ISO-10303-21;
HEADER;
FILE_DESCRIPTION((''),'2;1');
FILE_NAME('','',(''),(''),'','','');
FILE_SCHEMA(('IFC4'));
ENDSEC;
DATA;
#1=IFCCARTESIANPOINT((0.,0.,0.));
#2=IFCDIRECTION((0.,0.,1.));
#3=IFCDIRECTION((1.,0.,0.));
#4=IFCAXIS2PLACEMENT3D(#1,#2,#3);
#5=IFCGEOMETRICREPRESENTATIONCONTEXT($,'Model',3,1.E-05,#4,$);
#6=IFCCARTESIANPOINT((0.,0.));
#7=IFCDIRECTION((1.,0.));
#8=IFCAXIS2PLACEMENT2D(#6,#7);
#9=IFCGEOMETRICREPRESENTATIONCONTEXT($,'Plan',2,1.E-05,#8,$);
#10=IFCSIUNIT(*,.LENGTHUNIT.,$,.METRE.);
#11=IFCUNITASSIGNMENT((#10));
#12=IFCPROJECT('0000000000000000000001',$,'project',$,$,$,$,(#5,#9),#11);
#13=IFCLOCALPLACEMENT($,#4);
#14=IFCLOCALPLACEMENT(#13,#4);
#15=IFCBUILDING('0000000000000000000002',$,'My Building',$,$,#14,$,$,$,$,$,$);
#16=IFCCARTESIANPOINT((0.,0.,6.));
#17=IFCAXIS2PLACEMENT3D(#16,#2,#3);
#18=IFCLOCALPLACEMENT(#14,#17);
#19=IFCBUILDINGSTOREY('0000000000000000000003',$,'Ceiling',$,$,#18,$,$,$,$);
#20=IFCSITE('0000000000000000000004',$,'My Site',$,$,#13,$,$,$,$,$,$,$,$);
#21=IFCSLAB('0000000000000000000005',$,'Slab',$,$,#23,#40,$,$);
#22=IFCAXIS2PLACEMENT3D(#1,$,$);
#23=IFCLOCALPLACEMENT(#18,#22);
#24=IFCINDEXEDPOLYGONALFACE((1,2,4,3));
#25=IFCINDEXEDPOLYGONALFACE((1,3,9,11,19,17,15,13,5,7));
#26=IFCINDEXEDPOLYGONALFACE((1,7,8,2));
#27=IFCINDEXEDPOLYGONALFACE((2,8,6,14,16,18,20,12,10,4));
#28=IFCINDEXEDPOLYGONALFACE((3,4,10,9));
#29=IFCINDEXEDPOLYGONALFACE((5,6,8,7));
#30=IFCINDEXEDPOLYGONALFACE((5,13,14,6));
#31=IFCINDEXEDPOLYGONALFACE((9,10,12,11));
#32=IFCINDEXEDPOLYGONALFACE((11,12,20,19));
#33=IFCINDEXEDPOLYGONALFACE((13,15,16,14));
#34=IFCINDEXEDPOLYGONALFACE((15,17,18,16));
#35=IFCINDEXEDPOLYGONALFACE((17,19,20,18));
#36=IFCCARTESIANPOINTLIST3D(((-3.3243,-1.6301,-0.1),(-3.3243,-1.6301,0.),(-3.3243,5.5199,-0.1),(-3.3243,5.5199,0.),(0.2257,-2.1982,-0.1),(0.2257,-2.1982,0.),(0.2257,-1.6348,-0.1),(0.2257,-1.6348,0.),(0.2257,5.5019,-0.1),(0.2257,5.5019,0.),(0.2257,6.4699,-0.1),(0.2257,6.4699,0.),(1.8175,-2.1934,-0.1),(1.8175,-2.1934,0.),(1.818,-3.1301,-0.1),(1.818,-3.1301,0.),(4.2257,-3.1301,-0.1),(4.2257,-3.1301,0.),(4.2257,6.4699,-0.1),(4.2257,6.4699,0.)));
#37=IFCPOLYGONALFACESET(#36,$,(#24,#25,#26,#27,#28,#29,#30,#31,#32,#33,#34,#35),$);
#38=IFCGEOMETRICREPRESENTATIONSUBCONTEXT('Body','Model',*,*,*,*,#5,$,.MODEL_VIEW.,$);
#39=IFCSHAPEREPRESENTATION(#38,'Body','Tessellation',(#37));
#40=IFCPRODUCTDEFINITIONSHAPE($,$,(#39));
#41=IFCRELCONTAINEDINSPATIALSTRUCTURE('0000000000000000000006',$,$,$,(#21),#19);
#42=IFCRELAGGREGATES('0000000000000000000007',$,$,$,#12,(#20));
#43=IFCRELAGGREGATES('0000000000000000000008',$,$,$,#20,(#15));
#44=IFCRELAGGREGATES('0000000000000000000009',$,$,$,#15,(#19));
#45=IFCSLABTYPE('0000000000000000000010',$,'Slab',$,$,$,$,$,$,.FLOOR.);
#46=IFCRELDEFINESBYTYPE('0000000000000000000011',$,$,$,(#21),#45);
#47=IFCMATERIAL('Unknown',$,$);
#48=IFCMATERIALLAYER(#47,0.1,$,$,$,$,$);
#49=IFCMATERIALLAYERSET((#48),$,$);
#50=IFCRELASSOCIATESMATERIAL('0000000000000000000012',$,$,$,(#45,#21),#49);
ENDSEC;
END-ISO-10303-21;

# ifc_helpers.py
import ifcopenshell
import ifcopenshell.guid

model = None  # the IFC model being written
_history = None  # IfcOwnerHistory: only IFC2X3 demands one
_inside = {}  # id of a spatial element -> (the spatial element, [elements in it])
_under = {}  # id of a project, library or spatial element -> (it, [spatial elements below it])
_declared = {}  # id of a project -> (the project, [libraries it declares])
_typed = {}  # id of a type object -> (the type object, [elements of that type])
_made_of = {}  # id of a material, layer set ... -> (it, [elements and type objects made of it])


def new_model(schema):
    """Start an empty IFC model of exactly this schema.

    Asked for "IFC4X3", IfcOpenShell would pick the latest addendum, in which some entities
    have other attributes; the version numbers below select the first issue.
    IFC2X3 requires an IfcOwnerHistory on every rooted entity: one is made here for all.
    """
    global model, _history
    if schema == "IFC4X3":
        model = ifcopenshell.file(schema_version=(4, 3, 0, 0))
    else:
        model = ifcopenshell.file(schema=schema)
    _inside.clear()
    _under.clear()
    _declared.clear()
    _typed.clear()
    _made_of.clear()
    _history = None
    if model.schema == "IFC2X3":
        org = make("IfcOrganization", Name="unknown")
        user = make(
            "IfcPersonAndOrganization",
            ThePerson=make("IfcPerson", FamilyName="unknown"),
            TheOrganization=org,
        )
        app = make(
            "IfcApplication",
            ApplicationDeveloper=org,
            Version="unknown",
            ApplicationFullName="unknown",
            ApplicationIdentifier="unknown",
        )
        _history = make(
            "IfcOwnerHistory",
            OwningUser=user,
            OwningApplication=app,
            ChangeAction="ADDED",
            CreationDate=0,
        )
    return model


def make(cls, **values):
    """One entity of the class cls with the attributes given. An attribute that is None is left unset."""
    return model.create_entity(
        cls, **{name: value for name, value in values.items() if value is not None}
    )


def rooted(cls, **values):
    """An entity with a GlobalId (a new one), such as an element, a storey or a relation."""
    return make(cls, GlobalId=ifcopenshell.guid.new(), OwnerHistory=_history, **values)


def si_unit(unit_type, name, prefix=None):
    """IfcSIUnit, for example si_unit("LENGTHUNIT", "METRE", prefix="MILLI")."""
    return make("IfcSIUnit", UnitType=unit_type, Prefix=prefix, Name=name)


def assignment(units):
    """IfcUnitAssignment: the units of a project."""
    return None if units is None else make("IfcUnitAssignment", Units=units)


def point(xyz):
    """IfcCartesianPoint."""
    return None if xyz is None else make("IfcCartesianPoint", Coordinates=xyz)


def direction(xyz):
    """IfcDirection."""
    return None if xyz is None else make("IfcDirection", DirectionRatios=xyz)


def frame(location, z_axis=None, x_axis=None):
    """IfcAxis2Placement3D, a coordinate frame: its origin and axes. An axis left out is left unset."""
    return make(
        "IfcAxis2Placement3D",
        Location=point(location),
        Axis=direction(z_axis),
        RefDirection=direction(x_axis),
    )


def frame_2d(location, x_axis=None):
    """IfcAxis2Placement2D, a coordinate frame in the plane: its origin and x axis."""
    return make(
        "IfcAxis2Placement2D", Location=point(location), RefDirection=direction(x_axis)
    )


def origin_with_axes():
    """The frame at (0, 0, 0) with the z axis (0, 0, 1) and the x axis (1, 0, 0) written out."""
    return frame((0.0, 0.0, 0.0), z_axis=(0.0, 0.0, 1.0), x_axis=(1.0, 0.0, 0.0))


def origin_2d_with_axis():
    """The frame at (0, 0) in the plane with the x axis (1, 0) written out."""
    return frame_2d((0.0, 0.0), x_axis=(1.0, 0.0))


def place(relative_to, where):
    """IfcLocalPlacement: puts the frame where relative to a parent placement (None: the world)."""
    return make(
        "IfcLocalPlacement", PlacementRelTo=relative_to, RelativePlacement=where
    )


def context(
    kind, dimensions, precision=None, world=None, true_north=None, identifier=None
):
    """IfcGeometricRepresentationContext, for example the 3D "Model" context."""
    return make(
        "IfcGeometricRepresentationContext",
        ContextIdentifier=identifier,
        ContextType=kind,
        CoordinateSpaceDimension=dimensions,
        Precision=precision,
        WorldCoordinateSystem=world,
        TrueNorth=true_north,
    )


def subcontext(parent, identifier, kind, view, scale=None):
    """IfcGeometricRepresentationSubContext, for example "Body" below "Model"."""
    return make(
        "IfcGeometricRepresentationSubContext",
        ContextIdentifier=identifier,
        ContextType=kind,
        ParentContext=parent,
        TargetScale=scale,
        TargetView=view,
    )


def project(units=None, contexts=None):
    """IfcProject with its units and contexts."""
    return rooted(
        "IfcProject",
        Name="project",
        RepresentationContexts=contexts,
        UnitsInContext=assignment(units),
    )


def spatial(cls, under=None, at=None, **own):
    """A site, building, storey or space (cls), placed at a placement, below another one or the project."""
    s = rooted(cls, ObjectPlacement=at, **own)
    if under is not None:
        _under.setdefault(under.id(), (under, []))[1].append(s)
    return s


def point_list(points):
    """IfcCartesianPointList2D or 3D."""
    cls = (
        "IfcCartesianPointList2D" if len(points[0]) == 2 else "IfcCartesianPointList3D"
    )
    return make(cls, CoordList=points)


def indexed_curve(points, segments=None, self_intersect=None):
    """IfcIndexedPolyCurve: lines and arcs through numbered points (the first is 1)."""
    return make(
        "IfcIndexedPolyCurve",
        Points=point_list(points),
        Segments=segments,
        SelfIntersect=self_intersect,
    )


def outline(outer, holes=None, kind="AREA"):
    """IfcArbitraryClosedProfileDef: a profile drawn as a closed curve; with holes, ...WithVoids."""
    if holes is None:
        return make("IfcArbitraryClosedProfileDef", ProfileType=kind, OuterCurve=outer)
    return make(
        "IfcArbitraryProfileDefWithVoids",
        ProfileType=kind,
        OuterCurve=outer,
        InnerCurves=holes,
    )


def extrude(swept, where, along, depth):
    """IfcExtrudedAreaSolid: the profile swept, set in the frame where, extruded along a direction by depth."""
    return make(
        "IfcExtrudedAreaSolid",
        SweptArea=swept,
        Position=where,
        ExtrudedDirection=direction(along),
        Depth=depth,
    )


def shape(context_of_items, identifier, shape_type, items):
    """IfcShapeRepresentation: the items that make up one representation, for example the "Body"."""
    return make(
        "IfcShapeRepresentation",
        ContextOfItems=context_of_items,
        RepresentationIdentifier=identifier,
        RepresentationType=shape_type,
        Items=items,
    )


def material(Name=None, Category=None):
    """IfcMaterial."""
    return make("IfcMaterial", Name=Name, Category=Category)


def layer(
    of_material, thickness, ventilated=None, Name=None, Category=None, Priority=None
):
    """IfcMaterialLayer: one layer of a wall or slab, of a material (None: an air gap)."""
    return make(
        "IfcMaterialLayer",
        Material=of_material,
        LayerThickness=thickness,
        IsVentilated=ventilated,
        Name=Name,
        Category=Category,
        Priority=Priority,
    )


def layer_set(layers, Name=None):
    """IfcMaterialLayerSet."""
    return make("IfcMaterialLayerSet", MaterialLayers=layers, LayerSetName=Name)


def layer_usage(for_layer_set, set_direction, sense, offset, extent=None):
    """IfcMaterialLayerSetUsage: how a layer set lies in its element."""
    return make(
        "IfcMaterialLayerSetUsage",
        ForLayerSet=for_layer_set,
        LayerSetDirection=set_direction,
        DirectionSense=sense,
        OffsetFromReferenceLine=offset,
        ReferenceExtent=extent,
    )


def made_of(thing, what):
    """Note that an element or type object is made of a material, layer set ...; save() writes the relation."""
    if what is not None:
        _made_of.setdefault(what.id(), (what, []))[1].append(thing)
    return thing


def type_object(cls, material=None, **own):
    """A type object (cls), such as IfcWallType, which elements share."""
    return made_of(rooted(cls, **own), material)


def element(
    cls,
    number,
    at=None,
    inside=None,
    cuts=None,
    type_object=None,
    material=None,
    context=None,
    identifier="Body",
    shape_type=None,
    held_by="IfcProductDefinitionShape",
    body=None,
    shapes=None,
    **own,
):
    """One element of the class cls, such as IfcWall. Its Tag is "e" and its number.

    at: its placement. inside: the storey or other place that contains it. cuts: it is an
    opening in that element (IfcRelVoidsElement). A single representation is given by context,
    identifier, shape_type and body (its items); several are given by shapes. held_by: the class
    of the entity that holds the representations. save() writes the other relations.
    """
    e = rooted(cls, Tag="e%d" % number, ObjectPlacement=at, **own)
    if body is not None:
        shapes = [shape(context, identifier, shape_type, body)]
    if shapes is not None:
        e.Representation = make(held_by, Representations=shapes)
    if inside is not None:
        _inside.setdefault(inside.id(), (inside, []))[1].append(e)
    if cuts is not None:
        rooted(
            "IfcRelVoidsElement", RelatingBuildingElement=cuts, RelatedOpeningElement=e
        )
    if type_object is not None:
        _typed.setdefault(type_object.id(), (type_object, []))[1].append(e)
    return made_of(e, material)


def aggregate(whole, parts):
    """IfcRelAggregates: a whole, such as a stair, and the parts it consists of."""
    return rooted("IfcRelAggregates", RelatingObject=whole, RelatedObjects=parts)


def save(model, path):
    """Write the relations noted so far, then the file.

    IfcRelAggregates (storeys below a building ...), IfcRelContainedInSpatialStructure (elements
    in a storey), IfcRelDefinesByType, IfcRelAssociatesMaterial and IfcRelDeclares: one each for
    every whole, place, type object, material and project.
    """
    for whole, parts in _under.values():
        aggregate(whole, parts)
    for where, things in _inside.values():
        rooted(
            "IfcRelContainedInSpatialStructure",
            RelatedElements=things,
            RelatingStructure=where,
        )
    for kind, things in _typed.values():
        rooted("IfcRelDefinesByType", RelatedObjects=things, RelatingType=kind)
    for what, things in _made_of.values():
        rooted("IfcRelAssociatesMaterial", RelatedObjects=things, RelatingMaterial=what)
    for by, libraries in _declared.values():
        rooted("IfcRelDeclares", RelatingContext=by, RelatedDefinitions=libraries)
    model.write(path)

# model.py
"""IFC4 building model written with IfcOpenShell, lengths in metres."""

from ifc_helpers import new_model, si_unit, frame, origin_with_axes, origin_2d_with_axis, place, context, subcontext, project, spatial, indexed_curve, outline, extrude, material, layer, layer_set, layer_usage, type_object, element, save


model = new_model("IFC4")

# Units and contexts
model_context = context("Model", 3, precision=1e-05, world=origin_with_axes())
plan_context = context("Plan", 2, precision=1e-05, world=origin_2d_with_axis())
body_context = subcontext(model_context, "Body", "Model", "MODEL_VIEW")
ifc_project = project(units=[si_unit("LENGTHUNIT", "METRE")], contexts=[model_context, plan_context])

# Site, building, storey
site_placement = place(None, origin_with_axes())
site = spatial("IfcSite", under=ifc_project, at=site_placement, Name="My Site")
building_placement = place(site_placement, origin_with_axes())
building = spatial("IfcBuilding", under=site, at=building_placement, Name="My Building")
storey_placement = place(building_placement, frame((0.0, 0.0, 6.0), z_axis=(0.0, 0.0, 1.0), x_axis=(1.0, 0.0, 0.0)))
storey = spatial("IfcBuildingStorey", under=building, at=storey_placement, Name="Ceiling")

# Slab
ifc_material = material(Name="Unknown")
ifc_layer = layer(ifc_material, 0.1)
ifc_layer_set = layer_set([ifc_layer])
ifc_layer_usage = layer_usage(ifc_layer_set, "AXIS3", "POSITIVE", -0.1)
slab_type = type_object("IfcSlabType", Name="Slab", PredefinedType="FLOOR", material=ifc_layer_set)
slab_placement = place(storey_placement, frame((4.2257, 6.4699, 0.0), z_axis=(0.0, 0.0, 1.0), x_axis=(1.0, 0.0, 0.0)))
element("IfcSlab", 1, at=slab_placement, inside=storey, type_object=slab_type, material=ifc_layer_usage, Name="Slab", context=body_context, shape_type="SweptSolid", body=[
    extrude(outline(indexed_curve([(0.0, 0.0), (-4.0, 0.0), (-4.0, -0.968), (-7.55, -0.95), (-7.55, -8.1), (-4.0, -8.1046), (-4.0, -8.6681), (-2.4083, -8.6632), (-2.4077, -9.6), (0.0, -9.6), (0.0, 0.0)])), frame((0.0, 0.0, -0.1), z_axis=(0.0, 0.0, 1.0), x_axis=(1.0, 0.0, 0.0)), (0.0, 0.0, 1.0), 0.1),
])

save(model, "model.ifc")
